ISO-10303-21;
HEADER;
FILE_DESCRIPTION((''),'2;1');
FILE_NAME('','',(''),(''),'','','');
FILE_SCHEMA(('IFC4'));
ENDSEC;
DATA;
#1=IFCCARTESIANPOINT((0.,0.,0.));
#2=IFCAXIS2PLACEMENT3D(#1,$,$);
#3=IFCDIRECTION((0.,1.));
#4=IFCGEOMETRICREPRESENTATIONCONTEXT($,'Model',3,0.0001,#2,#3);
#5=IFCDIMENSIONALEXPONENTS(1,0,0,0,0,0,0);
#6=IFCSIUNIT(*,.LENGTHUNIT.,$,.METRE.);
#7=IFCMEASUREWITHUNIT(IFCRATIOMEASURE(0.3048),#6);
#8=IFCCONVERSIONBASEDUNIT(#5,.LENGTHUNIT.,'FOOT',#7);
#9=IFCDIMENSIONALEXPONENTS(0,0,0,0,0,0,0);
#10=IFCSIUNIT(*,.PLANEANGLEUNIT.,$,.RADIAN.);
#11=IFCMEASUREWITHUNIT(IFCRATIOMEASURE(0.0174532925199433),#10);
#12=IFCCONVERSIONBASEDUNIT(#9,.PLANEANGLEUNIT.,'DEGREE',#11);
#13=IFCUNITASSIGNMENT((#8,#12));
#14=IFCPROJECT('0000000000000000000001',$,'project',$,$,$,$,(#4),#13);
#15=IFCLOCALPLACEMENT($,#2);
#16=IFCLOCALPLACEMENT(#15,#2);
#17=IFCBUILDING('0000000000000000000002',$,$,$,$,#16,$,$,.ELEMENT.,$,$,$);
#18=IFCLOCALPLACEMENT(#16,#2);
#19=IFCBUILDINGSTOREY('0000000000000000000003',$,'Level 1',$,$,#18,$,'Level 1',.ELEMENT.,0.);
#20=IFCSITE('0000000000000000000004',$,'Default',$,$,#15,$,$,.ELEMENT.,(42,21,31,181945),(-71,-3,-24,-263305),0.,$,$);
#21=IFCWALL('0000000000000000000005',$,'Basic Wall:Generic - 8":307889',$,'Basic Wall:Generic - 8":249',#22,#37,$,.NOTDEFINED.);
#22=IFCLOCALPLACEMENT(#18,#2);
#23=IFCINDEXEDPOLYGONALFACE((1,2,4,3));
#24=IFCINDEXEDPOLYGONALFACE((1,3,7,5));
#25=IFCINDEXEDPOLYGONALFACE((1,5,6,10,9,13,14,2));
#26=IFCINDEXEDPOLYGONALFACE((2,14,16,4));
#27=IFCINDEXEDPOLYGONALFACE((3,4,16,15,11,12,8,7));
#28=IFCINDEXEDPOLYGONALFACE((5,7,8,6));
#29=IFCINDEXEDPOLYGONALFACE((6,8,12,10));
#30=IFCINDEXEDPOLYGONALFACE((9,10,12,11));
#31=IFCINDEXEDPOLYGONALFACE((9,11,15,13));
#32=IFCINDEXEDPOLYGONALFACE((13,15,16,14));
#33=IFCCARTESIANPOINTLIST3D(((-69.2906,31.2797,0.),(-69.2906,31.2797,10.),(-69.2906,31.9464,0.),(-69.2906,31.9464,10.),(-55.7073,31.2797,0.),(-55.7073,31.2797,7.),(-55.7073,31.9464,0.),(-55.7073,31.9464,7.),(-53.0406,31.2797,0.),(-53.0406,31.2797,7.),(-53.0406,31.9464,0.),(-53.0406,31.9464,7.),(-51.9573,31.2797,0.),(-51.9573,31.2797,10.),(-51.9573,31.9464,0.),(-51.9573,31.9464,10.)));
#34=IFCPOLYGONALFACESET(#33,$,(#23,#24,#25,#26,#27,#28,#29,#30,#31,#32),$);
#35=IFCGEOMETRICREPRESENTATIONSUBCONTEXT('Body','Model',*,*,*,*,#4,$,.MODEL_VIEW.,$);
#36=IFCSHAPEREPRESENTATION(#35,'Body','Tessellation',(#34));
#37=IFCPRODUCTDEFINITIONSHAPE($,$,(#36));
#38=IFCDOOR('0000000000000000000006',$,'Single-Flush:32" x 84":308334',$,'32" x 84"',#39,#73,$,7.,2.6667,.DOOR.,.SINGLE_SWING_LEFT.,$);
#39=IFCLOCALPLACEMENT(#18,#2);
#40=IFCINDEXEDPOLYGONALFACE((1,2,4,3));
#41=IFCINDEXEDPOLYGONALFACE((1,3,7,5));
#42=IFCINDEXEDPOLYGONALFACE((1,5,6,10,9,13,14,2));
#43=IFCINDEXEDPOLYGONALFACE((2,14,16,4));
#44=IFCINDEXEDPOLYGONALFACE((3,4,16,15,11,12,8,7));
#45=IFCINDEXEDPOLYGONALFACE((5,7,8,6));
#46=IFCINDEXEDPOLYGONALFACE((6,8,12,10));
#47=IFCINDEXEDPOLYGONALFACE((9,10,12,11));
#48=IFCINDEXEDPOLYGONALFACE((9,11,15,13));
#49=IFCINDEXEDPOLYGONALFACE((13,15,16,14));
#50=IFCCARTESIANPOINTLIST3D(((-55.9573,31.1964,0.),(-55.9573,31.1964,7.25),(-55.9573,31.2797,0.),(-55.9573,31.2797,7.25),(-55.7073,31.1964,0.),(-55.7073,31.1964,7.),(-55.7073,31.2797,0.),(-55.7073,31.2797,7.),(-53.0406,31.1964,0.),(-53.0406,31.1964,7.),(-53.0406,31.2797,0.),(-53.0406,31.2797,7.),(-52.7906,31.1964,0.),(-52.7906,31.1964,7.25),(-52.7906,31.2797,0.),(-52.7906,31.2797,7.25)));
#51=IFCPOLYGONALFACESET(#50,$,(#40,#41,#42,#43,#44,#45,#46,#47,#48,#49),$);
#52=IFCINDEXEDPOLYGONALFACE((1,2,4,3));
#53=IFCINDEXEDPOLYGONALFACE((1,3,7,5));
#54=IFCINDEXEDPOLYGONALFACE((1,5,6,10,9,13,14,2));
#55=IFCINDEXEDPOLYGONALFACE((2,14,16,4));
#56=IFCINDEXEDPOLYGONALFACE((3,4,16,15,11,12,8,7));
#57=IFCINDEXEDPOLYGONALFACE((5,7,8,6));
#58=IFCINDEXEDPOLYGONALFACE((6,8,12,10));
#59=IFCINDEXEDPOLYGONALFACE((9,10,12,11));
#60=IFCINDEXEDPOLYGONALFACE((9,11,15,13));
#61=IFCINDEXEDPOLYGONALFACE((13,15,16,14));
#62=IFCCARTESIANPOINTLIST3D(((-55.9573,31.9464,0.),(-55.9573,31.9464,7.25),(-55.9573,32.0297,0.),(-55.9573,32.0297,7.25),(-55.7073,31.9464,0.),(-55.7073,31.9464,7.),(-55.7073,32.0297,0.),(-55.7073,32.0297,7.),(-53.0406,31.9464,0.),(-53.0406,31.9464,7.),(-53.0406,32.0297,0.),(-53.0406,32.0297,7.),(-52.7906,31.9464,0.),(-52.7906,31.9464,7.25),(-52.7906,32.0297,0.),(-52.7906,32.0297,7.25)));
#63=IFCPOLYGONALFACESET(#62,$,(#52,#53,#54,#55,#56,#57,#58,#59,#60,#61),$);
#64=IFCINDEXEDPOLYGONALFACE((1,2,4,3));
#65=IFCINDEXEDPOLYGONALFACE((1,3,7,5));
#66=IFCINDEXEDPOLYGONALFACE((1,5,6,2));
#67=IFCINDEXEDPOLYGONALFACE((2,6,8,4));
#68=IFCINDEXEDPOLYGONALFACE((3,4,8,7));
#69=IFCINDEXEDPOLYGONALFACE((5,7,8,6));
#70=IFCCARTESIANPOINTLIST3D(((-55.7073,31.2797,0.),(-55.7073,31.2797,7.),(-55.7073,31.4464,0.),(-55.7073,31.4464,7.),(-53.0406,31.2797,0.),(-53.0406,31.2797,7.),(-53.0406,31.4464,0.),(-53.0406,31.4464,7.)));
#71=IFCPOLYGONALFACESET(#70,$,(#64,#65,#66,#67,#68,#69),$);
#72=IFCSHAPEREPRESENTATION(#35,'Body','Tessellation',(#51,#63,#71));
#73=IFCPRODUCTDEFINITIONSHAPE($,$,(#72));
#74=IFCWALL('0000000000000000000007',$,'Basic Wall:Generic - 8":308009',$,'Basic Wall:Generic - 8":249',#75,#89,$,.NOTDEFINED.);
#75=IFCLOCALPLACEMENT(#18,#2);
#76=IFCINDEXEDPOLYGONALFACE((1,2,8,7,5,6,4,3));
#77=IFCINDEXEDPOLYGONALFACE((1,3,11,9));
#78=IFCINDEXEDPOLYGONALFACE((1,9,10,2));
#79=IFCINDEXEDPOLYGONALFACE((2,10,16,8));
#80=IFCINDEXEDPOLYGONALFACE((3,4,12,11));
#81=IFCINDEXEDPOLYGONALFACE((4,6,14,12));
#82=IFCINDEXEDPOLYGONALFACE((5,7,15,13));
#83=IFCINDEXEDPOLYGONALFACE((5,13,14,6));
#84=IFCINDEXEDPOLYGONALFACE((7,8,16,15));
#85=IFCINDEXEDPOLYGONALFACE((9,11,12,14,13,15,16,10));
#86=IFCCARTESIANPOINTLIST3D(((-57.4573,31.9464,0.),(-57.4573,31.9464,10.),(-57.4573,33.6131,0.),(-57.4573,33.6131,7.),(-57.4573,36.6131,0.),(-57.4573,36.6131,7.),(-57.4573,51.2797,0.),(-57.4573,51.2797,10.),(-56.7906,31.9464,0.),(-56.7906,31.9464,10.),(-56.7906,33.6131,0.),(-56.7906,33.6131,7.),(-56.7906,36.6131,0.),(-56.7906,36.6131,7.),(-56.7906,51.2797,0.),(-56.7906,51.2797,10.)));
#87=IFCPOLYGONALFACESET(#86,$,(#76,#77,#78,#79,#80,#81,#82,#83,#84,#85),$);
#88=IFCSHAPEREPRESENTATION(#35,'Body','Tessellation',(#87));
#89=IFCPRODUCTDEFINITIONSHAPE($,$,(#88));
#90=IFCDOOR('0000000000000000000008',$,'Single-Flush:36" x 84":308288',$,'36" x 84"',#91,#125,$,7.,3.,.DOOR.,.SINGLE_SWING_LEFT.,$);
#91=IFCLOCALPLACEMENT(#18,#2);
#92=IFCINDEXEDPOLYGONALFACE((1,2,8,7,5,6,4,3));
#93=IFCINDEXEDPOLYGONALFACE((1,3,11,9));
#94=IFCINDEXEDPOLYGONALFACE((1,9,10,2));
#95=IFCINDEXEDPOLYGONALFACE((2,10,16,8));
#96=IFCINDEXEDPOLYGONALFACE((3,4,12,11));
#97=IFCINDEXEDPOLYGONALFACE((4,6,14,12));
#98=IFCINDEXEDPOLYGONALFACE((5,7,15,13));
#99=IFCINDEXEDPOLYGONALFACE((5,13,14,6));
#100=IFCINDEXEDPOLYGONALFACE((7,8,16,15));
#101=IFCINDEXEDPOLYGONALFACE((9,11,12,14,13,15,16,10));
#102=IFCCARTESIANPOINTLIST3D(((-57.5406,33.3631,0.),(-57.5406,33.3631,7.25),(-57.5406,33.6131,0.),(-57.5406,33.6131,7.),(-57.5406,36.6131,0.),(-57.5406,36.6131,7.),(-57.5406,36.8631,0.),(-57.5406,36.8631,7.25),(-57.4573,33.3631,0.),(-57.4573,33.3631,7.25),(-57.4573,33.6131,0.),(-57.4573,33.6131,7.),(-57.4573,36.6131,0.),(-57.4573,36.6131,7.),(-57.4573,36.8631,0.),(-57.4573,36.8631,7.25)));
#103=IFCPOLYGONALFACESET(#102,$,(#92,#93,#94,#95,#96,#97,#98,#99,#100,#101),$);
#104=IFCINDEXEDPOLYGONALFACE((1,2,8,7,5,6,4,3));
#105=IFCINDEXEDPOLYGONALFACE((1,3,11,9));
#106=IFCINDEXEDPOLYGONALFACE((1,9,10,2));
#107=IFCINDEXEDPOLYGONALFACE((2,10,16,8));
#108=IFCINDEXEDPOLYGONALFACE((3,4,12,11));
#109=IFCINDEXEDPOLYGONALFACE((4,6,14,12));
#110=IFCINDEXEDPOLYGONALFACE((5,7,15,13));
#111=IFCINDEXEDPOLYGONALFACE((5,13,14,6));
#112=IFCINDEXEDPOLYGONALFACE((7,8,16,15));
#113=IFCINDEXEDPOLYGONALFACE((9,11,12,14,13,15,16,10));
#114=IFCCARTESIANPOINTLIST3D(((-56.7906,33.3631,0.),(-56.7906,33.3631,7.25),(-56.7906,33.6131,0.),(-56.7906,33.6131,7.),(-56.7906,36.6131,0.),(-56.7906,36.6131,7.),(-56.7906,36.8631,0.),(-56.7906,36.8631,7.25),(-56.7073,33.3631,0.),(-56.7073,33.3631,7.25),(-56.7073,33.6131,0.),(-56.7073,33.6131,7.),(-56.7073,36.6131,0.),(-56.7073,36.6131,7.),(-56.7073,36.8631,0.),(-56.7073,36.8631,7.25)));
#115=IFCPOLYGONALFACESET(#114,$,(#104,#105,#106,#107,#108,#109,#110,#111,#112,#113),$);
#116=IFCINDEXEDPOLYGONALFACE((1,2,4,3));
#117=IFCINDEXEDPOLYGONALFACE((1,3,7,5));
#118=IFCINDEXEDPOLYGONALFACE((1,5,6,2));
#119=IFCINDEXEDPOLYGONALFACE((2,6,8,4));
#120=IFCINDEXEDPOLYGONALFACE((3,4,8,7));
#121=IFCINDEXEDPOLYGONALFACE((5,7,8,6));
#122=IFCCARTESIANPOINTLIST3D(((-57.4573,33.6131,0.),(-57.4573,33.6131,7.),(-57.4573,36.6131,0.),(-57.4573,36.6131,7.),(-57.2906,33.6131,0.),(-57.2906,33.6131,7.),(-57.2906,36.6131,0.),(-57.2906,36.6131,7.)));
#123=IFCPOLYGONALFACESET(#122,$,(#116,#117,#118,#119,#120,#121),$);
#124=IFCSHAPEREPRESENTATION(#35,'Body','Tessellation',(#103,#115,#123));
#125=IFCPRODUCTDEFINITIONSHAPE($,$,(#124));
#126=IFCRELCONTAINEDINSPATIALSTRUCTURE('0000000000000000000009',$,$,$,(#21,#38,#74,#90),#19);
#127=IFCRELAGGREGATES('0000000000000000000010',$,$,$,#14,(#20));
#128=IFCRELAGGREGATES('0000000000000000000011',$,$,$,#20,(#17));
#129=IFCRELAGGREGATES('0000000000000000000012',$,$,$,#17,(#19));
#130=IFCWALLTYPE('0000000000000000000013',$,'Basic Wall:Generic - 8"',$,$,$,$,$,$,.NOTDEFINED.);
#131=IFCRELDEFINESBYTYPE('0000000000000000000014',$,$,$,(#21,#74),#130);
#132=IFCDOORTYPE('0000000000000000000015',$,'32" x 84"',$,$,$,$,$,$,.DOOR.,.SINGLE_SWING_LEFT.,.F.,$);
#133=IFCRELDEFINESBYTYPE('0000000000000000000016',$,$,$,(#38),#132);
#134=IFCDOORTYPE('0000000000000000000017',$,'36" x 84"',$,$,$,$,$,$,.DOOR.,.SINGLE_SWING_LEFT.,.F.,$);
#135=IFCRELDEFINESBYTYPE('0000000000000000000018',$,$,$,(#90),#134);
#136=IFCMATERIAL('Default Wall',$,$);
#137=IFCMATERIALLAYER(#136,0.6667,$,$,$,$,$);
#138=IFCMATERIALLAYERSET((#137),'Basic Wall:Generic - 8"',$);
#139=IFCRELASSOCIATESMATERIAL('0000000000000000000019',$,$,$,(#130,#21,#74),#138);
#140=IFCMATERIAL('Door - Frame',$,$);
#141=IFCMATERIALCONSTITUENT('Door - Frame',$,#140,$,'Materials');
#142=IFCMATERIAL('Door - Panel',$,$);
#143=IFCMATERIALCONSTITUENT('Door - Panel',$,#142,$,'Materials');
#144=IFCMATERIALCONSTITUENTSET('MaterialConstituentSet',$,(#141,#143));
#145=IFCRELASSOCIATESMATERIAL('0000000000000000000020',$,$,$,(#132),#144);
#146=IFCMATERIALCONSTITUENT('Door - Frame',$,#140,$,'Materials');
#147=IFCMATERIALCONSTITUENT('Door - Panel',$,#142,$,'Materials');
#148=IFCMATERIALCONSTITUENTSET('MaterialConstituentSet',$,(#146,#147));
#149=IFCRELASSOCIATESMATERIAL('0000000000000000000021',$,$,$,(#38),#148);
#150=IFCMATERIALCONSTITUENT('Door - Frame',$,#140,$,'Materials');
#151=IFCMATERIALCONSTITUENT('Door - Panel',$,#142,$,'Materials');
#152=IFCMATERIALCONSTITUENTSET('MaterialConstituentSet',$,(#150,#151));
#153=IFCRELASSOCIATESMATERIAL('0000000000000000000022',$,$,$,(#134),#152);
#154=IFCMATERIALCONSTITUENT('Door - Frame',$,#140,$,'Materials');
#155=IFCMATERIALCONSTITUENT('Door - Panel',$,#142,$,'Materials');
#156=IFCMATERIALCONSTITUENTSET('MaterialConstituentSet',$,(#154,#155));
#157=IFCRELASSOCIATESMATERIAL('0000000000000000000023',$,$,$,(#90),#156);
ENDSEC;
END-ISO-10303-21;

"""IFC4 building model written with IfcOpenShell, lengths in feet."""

from ifc_helpers import new_model, entity, si_unit, converted_unit, direction, frame, frame_2d, origin, place, context, subcontext, project, spatial, polyline, rectangle, outline, extrude, source, transform, mapped, material, layer, layer_set, layer_usage, constituent, constituent_set, type_object, type_shapes, element, fill, save


model = new_model("IFC4")

# Units and contexts
model_context = context("Model", 3, precision=0.0001, world=origin(), true_north=direction((0.0, 1.0)))
body_context = subcontext(model_context, "Body", "Model", "MODEL_VIEW")
ifc_project = project(units=[converted_unit("LENGTHUNIT", "FOOT", entity("IfcRatioMeasure", 0.3048), si_unit("LENGTHUNIT", "METRE"), dimensions=[1, 0, 0, 0, 0, 0, 0]), converted_unit("PLANEANGLEUNIT", "DEGREE", entity("IfcRatioMeasure", 0.0174532925199433), si_unit("PLANEANGLEUNIT", "RADIAN"), dimensions=[0, 0, 0, 0, 0, 0, 0])], contexts=[model_context])

# Site, building, storey
site_placement = place(None, origin())
site = spatial("IfcSite", under=ifc_project, at=site_placement, Name="Default", CompositionType="ELEMENT", RefLatitude=(42, 21, 31, 181945), RefLongitude=(-71, -3, -24, -263305), RefElevation=0.0)
building_placement = place(site_placement, origin())
building = spatial("IfcBuilding", under=site, at=building_placement, CompositionType="ELEMENT")
storey_placement = place(building_placement, origin())
storey = spatial("IfcBuildingStorey", under=building, at=storey_placement, Name="Level 1", LongName="Level 1", CompositionType="ELEMENT", Elevation=0.0)

# Shared definitions
ifc_material_1 = material(Name="Default Wall")
ifc_layer = layer(ifc_material_1, 0.6667)
ifc_layer_set = layer_set([ifc_layer], Name="Basic Wall:Generic - 8\"")
wall_type = type_object("IfcWallType", Name="Basic Wall:Generic - 8\"", PredefinedType="NOTDEFINED", material=ifc_layer_set)

# Walls, openings, doors
ifc_layer_usage_1 = layer_usage(ifc_layer_set, "AXIS2", "NEGATIVE", 0.3333)
wall_1_placement = place(storey_placement, frame((-51.9573, 31.6131, 0.0), z_axis=(0.0, 0.0, 1.0), x_axis=(-1.0, 0.0, 0.0)))
wall_1 = element("IfcWall", 1, at=wall_1_placement, inside=storey, type_object=wall_type, material=ifc_layer_usage_1, Name="Basic Wall:Generic - 8\":307889", ObjectType="Basic Wall:Generic - 8\":249", PredefinedType="NOTDEFINED", context=body_context, shape_type="SweptSolid", body=[
    extrude(rectangle(XDim=17.3333, YDim=0.6667, at=frame_2d((8.6667, 0.0), x_axis=(-1.0, 0.0))), origin(), (0.0, 0.0, 1.0), 10.0),
])
opening_1_placement = place(wall_1_placement, frame((1.0833, -0.3333, 0.0)))
opening_1 = element("IfcOpeningElement", 2, at=opening_1_placement, cuts=wall_1, ObjectType="Opening", PredefinedType="OPENING", context=body_context, shape_type="SweptSolid", body=[
    extrude(rectangle(XDim=2.6667, YDim=7.0, at=frame_2d((3.5, 1.3333), x_axis=(0.0, -1.0))), frame((0.0, 0.0, 0.0), z_axis=(0.0, 1.0, 0.0), x_axis=(0.0, 0.0, 1.0)), (0.0, 0.0, 1.0), 0.6667),
])
ifc_material_2 = material(Name="Door - Frame")
ifc_constituent_1 = constituent(ifc_material_2, Name="Door - Frame", Category="Materials")
ifc_material_3 = material(Name="Door - Panel")
ifc_constituent_2 = constituent(ifc_material_3, Name="Door - Panel", Category="Materials")
ifc_constituent_set_1 = constituent_set(constituents=[ifc_constituent_1, ifc_constituent_2], Name="MaterialConstituentSet")
ifc_constituent_3 = constituent(ifc_material_2, Name="Door - Frame", Category="Materials")
ifc_constituent_4 = constituent(ifc_material_3, Name="Door - Panel", Category="Materials")
ifc_constituent_set_2 = constituent_set(constituents=[ifc_constituent_3, ifc_constituent_4], Name="MaterialConstituentSet")
door_type_1 = type_object("IfcDoorType", Name="32\" x 84\"", OperationType="SINGLE_SWING_LEFT", ParameterTakesPrecedence=False, PredefinedType="DOOR", material=ifc_constituent_set_2)
shared_shape_1 = source(origin(), body_context, "Body", "SweptSolid", [
    extrude(outline(polyline([(-1.5833, -3.6875), (1.5833, -3.6875), (1.5833, 3.5625), (1.3333, 3.5625), (1.3333, -3.4375), (-1.3333, -3.4375), (-1.3333, 3.5625), (-1.5833, 3.5625), (-1.5833, -3.6875)])), frame((1.3333, 0.75, 3.5625), z_axis=(0.0, -1.0, 0.0), x_axis=(-1.0, 0.0, 0.0)), (0.0, 0.0, 1.0), 0.0833),
    extrude(outline(polyline([(-3.6875, -1.5833), (3.5625, -1.5833), (3.5625, -1.3333), (-3.4375, -1.3333), (-3.4375, 1.3333), (3.5625, 1.3333), (3.5625, 1.5833), (-3.6875, 1.5833), (-3.6875, -1.5833)])), frame((1.3333, 0.0, 3.5625), z_axis=(0.0, -1.0, 0.0), x_axis=(0.0, 0.0, -1.0)), (0.0, 0.0, 1.0), 0.0833),
    extrude(rectangle(XDim=2.6667, YDim=0.1667, at=frame_2d((0.0, 0.0), x_axis=(1.0, 0.0))), frame((1.3333, 0.5833, 0.0)), (0.0, 0.0, 1.0), 7.0),
])
type_shapes(door_type_1, [shared_shape_1])
door_1_placement = place(opening_1_placement, origin())
door_1 = element("IfcDoor", 3, at=door_1_placement, inside=storey, type_object=door_type_1, material=ifc_constituent_set_1, Name="Single-Flush:32\" x 84\":308334", ObjectType="32\" x 84\"", OperationType="SINGLE_SWING_LEFT", OverallHeight=7.0, OverallWidth=2.6667, PredefinedType="DOOR", context=body_context, shape_type="MappedRepresentation", body=[
    mapped(shared_shape_1, transform((0.0, 0.0, 0.0), scale=1.0)),
])
fill(opening_1, door_1)
ifc_layer_usage_2 = layer_usage(ifc_layer_set, "AXIS2", "NEGATIVE", 0.3333)
wall_2_placement = place(storey_placement, frame((-57.1239, 31.9464, 0.0), z_axis=(0.0, 0.0, 1.0), x_axis=(0.0, 1.0, 0.0)))
wall_2 = element("IfcWall", 4, at=wall_2_placement, inside=storey, type_object=wall_type, material=ifc_layer_usage_2, Name="Basic Wall:Generic - 8\":308009", ObjectType="Basic Wall:Generic - 8\":249", PredefinedType="NOTDEFINED", context=body_context, shape_type="SweptSolid", body=[
    extrude(rectangle(XDim=19.3333, YDim=0.6667, at=frame_2d((9.6667, 0.0), x_axis=(-1.0, 0.0))), origin(), (0.0, 0.0, 1.0), 10.0),
])
opening_2_placement = place(wall_2_placement, frame((1.6667, -0.3333, 0.0)))
opening_2 = element("IfcOpeningElement", 5, at=opening_2_placement, cuts=wall_2, ObjectType="Opening", PredefinedType="OPENING", context=body_context, shape_type="SweptSolid", body=[
    extrude(rectangle(XDim=3.0, YDim=7.0, at=frame_2d((3.5, 1.5), x_axis=(0.0, -1.0))), frame((0.0, 0.0, 0.0), z_axis=(0.0, 1.0, 0.0), x_axis=(0.0, 0.0, 1.0)), (0.0, 0.0, 1.0), 0.6667),
])
ifc_constituent_5 = constituent(ifc_material_2, Name="Door - Frame", Category="Materials")
ifc_constituent_6 = constituent(ifc_material_3, Name="Door - Panel", Category="Materials")
ifc_constituent_set_3 = constituent_set(constituents=[ifc_constituent_5, ifc_constituent_6], Name="MaterialConstituentSet")
ifc_constituent_7 = constituent(ifc_material_2, Name="Door - Frame", Category="Materials")
ifc_constituent_8 = constituent(ifc_material_3, Name="Door - Panel", Category="Materials")
ifc_constituent_set_4 = constituent_set(constituents=[ifc_constituent_7, ifc_constituent_8], Name="MaterialConstituentSet")
door_type_2 = type_object("IfcDoorType", Name="36\" x 84\"", OperationType="SINGLE_SWING_LEFT", ParameterTakesPrecedence=False, PredefinedType="DOOR", material=ifc_constituent_set_4)
shared_shape_2 = source(origin(), body_context, "Body", "SweptSolid", [
    extrude(outline(polyline([(-1.75, -3.6875), (1.75, -3.6875), (1.75, 3.5625), (1.5, 3.5625), (1.5, -3.4375), (-1.5, -3.4375), (-1.5, 3.5625), (-1.75, 3.5625), (-1.75, -3.6875)])), frame((1.5, 0.75, 3.5625), z_axis=(0.0, -1.0, 0.0), x_axis=(-1.0, 0.0, 0.0)), (0.0, 0.0, 1.0), 0.0833),
    extrude(outline(polyline([(-3.6875, -1.75), (3.5625, -1.75), (3.5625, -1.5), (-3.4375, -1.5), (-3.4375, 1.5), (3.5625, 1.5), (3.5625, 1.75), (-3.6875, 1.75), (-3.6875, -1.75)])), frame((1.5, 0.0, 3.5625), z_axis=(0.0, -1.0, 0.0), x_axis=(0.0, 0.0, -1.0)), (0.0, 0.0, 1.0), 0.0833),
    extrude(rectangle(XDim=3.0, YDim=0.1667, at=frame_2d((0.0, 0.0), x_axis=(1.0, 0.0))), frame((1.5, 0.5833, 0.0)), (0.0, 0.0, 1.0), 7.0),
])
type_shapes(door_type_2, [shared_shape_2])
door_2_placement = place(opening_2_placement, origin())
door_2 = element("IfcDoor", 6, at=door_2_placement, inside=storey, type_object=door_type_2, material=ifc_constituent_set_3, Name="Single-Flush:36\" x 84\":308288", ObjectType="36\" x 84\"", OperationType="SINGLE_SWING_LEFT", OverallHeight=7.0, OverallWidth=3.0, PredefinedType="DOOR", context=body_context, shape_type="MappedRepresentation", body=[
    mapped(shared_shape_2, transform((0.0, 0.0, 0.0), scale=1.0)),
])
fill(opening_2, door_2)

save(model, "model.ifc")
